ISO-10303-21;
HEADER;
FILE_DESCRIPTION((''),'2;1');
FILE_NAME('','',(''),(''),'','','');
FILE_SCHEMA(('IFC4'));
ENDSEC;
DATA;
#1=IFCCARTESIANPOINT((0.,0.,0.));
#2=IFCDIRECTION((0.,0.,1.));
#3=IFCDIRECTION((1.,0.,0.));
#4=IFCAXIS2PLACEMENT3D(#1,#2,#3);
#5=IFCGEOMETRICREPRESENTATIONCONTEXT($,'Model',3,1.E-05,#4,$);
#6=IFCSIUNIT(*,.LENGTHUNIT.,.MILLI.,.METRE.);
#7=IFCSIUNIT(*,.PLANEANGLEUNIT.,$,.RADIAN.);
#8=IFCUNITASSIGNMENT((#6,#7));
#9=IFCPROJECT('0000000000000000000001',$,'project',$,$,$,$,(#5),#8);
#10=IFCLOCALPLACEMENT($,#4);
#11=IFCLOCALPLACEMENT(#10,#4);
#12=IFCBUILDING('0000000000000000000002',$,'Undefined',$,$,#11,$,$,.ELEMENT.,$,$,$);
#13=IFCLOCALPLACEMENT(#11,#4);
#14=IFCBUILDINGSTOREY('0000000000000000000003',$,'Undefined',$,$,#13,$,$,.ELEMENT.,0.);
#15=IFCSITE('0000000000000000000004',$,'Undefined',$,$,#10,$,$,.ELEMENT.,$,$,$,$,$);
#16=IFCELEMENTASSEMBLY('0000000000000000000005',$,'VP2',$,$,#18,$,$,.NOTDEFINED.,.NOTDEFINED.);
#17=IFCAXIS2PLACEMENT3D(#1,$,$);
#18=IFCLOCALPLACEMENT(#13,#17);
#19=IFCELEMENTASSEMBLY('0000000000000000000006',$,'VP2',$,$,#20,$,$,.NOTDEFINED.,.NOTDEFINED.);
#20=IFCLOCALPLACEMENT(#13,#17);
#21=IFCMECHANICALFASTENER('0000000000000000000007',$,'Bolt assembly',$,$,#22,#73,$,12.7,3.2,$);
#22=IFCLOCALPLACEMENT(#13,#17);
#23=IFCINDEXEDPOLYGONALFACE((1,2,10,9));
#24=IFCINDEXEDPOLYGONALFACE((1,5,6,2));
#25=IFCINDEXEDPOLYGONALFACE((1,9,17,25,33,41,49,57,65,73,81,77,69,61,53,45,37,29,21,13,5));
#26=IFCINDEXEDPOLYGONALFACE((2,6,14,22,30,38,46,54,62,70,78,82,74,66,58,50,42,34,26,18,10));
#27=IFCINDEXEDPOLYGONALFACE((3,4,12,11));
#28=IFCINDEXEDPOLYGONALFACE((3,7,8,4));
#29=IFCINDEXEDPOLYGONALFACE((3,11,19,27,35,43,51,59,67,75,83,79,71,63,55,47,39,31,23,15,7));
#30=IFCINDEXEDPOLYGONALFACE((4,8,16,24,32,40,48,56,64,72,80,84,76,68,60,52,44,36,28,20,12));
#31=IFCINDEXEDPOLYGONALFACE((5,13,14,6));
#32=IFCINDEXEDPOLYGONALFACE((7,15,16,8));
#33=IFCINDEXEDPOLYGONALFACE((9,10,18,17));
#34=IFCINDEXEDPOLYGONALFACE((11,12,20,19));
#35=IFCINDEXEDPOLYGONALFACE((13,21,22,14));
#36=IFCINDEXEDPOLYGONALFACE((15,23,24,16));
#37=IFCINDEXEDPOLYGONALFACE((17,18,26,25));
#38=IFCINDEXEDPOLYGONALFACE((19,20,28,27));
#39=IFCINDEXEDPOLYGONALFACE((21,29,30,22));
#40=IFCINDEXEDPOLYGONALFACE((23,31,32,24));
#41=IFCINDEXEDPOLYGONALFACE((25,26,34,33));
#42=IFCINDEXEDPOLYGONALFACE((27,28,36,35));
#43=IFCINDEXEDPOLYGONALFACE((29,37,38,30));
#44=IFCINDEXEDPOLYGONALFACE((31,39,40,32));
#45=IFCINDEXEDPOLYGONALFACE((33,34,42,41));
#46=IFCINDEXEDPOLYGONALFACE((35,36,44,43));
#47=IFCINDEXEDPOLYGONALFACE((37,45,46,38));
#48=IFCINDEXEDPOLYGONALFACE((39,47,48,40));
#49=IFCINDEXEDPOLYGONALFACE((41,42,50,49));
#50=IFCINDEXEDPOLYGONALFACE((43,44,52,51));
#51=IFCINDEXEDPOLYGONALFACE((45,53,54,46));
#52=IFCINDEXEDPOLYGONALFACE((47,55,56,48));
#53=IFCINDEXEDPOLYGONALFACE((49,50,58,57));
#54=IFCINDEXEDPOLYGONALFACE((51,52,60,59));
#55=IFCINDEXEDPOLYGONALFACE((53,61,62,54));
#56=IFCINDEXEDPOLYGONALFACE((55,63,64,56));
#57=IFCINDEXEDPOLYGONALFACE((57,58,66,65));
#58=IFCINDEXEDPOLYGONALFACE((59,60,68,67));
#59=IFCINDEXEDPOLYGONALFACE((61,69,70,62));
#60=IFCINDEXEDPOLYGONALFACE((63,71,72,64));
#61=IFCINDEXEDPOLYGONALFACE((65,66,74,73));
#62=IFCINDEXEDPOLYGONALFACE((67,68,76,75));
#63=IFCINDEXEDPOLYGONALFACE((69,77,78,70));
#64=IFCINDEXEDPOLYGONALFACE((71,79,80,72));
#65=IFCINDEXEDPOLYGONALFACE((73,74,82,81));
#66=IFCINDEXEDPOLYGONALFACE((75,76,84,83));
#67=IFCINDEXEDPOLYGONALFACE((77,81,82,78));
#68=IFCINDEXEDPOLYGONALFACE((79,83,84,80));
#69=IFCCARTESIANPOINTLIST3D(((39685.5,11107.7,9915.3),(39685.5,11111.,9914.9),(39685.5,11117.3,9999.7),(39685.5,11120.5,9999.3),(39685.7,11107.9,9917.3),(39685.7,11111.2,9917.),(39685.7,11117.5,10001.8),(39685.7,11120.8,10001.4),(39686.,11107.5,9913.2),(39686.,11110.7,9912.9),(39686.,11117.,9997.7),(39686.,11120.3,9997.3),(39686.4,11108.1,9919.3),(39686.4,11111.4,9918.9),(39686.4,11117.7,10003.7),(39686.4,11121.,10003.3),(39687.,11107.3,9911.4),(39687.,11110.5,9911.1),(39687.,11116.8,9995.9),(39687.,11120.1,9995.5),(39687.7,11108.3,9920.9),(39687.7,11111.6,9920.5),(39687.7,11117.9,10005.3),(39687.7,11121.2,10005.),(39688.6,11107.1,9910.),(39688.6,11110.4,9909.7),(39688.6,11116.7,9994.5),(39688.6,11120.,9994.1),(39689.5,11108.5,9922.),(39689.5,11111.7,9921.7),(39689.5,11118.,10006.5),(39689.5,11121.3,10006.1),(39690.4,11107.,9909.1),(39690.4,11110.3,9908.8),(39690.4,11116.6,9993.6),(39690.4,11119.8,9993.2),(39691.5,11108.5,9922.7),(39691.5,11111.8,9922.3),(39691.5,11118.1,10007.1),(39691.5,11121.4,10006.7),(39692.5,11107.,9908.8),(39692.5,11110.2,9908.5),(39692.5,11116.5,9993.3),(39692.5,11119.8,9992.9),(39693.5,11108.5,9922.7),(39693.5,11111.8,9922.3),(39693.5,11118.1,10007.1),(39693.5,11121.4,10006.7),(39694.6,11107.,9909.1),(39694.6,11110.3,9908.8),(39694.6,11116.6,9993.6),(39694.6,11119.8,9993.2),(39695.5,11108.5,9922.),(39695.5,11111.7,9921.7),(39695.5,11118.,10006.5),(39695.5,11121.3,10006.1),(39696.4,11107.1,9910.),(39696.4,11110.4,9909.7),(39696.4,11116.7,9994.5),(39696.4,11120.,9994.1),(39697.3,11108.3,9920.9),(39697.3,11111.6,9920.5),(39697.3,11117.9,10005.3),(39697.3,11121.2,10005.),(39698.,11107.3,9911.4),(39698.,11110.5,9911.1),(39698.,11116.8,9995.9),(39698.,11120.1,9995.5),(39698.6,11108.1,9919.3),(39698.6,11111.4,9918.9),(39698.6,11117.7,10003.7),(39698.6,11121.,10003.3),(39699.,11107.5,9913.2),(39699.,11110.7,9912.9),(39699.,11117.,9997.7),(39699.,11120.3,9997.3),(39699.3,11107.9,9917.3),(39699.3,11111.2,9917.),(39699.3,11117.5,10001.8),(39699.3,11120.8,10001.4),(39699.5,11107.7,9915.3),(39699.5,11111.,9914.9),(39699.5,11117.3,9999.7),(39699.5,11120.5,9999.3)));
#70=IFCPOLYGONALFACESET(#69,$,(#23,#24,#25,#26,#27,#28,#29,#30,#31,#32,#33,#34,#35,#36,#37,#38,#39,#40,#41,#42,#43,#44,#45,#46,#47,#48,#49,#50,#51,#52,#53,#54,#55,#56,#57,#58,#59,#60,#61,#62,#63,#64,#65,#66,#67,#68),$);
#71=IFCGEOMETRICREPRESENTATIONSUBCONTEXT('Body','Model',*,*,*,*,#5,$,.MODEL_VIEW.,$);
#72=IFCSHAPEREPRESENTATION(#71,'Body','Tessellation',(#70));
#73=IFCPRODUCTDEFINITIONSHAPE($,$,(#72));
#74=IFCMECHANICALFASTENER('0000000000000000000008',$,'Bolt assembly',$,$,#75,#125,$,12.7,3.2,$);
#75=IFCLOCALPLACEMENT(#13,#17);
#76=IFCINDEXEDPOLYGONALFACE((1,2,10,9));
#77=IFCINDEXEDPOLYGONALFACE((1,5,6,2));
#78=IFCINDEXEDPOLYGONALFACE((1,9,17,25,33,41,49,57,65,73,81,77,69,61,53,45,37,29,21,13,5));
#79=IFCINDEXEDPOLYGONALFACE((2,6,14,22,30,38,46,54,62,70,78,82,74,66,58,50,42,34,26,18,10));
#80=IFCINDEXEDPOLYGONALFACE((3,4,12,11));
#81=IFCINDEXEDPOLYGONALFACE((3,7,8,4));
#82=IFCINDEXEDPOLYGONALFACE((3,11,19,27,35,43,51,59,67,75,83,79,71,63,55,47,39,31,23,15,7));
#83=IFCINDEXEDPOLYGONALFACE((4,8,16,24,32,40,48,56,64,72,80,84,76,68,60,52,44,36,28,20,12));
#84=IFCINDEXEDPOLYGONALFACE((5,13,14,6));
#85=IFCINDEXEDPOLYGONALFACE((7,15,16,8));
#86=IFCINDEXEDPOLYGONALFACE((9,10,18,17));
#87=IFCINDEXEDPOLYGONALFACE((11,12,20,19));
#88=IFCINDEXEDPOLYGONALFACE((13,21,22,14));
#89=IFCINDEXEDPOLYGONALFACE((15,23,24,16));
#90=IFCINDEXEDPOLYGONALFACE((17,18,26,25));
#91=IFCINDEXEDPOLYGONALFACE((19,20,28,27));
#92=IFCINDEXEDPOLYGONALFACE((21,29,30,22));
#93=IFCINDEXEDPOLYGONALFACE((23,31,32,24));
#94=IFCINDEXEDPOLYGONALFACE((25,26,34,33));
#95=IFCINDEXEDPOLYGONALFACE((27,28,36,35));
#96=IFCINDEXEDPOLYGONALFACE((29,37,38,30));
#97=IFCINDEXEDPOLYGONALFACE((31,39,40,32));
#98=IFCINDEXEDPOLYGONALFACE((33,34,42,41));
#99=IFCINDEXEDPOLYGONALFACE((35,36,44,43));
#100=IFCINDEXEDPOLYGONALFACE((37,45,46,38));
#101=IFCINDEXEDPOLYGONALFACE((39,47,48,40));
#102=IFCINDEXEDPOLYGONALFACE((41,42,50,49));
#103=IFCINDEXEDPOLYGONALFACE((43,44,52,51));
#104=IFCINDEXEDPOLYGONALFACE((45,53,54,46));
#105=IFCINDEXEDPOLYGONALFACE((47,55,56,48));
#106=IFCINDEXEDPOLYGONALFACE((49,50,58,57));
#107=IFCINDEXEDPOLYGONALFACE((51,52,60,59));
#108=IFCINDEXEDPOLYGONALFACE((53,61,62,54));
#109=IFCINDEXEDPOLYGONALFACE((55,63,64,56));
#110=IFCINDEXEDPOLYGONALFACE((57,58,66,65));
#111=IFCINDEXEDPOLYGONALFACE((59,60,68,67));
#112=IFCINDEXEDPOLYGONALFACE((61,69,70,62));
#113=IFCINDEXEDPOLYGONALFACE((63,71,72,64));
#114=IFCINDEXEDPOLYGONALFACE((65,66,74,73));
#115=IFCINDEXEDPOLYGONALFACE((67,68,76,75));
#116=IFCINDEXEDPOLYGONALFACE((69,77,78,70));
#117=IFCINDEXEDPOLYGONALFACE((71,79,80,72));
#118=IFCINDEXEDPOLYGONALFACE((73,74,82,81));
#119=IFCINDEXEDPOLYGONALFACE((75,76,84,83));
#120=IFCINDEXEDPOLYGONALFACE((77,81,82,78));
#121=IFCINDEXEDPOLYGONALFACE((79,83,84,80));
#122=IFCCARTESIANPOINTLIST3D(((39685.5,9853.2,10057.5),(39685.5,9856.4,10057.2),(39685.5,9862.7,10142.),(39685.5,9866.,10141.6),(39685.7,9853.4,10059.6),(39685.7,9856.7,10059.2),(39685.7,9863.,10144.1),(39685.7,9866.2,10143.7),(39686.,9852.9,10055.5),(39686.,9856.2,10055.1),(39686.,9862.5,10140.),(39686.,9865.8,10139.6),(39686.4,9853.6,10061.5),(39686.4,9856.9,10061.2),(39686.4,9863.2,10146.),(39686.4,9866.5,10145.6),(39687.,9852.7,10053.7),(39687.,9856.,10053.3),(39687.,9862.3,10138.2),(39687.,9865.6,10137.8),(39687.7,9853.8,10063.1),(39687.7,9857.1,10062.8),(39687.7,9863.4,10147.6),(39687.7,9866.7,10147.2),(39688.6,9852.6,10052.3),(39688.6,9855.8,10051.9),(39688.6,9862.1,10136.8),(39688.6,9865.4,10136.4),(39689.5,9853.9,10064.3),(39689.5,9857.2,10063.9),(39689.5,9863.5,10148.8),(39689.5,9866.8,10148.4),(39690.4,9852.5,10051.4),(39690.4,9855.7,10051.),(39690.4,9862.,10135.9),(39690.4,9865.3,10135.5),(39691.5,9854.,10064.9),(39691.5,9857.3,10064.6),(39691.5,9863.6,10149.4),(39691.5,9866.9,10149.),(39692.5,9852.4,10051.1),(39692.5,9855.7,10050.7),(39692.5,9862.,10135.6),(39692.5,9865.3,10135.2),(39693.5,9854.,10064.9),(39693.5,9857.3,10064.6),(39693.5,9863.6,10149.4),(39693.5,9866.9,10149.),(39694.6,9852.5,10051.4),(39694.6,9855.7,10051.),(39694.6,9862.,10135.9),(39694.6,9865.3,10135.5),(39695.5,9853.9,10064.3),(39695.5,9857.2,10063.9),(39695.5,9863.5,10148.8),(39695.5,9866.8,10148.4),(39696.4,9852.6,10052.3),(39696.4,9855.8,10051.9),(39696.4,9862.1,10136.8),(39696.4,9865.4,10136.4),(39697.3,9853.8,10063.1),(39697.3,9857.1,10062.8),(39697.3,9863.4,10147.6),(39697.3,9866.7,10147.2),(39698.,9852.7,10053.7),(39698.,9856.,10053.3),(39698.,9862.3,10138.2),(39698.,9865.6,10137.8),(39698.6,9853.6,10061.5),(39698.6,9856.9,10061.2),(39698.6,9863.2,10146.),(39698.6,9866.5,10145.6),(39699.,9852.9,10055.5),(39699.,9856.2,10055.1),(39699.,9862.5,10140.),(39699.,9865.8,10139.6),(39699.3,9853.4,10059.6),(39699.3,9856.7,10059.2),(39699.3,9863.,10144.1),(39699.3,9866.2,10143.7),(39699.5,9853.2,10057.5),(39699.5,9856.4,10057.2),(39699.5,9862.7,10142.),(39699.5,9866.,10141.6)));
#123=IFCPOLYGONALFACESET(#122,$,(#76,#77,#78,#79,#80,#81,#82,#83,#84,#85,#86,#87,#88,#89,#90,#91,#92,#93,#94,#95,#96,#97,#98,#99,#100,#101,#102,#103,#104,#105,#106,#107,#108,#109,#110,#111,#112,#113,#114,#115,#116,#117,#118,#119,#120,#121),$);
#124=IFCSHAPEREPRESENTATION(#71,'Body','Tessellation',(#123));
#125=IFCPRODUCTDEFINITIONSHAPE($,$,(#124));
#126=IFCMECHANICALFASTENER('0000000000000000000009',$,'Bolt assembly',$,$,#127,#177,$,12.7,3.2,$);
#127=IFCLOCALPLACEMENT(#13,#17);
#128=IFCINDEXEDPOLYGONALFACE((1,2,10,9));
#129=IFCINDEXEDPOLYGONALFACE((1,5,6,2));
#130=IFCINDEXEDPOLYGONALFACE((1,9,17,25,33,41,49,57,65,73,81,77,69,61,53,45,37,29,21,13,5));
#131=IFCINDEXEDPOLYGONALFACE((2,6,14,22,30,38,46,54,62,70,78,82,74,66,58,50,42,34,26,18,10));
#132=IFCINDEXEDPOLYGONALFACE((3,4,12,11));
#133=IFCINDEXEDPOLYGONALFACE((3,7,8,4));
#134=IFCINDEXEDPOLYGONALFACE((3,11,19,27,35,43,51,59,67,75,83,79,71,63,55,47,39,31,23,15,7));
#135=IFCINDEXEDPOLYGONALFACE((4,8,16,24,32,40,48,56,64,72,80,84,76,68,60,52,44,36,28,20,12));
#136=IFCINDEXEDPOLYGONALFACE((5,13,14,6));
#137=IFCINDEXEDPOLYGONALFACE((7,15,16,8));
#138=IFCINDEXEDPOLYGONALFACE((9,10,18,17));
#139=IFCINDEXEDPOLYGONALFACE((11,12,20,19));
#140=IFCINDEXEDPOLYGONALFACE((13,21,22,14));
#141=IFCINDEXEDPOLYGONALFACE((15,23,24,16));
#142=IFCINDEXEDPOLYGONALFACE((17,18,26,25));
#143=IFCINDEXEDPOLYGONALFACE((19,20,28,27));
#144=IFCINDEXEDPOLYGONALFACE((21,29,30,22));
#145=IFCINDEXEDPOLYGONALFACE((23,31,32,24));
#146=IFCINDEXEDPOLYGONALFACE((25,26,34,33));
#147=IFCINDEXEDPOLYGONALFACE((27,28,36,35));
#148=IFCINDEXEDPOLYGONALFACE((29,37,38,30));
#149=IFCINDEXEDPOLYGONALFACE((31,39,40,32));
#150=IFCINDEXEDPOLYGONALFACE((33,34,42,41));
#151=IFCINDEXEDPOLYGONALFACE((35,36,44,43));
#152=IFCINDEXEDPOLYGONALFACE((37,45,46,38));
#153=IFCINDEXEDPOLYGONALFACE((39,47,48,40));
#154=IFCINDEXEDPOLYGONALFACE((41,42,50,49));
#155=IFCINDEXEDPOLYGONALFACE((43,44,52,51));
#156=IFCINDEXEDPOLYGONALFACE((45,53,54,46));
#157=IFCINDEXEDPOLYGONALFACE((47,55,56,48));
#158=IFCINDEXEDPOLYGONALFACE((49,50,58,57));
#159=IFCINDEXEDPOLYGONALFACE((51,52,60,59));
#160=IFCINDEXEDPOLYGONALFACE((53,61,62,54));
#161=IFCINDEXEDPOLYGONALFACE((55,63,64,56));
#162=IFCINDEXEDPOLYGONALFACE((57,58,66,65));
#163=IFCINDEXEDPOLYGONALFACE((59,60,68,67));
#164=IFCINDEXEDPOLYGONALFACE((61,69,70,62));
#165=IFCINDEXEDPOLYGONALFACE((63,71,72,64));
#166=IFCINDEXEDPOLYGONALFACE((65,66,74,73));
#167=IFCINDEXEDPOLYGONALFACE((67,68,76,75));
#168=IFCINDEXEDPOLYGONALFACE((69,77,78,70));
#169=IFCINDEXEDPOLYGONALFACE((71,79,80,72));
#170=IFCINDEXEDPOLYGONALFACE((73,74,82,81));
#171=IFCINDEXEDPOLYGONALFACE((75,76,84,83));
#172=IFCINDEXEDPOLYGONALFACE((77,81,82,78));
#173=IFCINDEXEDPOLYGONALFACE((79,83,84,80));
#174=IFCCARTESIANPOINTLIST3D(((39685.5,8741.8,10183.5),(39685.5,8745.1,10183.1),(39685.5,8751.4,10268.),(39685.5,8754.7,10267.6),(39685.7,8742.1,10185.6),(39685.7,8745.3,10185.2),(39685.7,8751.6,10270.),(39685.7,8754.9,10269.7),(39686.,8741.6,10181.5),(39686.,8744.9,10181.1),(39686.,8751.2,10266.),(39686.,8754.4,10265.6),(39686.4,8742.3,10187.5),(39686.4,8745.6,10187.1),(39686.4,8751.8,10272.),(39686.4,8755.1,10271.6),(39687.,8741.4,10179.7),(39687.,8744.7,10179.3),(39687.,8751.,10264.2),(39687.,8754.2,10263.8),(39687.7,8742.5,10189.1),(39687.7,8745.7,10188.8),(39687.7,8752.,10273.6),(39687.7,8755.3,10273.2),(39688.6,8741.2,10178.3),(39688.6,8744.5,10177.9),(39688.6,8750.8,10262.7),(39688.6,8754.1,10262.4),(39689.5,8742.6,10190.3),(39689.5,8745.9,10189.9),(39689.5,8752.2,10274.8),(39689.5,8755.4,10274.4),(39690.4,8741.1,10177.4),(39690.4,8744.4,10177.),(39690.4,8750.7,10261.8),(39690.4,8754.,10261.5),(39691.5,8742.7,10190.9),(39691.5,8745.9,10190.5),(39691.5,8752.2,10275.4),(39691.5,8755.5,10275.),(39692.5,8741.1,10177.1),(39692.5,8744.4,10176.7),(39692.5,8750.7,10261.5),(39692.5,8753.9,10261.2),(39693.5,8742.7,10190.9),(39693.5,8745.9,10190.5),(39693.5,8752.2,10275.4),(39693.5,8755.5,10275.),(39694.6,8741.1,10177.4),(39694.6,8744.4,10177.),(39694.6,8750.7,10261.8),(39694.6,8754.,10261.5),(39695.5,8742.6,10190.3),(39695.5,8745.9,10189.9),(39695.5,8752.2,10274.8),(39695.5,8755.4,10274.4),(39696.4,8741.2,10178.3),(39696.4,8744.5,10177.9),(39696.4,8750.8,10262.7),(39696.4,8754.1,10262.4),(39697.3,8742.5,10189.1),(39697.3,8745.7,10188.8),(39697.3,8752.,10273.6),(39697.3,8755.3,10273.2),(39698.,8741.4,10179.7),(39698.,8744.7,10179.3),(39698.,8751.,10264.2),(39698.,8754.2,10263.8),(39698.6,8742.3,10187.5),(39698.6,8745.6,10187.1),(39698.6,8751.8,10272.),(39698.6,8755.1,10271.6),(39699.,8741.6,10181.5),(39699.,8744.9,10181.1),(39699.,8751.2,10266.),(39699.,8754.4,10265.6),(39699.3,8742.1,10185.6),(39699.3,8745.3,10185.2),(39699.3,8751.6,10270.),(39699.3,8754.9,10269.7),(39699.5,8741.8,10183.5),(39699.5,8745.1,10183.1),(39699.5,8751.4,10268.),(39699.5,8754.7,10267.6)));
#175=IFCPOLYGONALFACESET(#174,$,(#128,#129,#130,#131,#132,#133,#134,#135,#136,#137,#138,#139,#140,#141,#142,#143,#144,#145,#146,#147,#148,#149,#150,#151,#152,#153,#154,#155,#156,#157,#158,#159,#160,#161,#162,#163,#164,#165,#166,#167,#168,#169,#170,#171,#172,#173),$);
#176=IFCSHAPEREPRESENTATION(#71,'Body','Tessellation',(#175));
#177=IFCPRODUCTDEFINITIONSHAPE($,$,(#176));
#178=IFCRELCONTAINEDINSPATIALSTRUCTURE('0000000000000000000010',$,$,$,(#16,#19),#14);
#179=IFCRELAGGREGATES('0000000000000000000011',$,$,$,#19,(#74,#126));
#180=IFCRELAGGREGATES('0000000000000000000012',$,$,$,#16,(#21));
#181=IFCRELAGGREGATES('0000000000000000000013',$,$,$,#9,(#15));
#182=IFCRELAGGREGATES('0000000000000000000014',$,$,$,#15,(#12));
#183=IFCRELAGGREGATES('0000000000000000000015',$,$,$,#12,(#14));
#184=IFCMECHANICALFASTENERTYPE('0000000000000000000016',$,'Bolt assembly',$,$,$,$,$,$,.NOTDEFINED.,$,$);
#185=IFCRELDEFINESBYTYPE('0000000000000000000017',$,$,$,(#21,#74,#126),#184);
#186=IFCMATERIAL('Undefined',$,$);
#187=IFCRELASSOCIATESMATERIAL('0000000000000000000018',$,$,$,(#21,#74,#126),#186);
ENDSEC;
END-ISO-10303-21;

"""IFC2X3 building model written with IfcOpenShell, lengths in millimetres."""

from ifc_helpers import new_model, si_unit, frame, origin_with_axes, origin_2d_with_axis, place, context, subcontext, project, spatial, circle, extrude, source, transform, mapped, material, type_object, element, aggregate, save


model = new_model("IFC2X3")

# Units and contexts
model_context = context("Model", 3, precision=1e-05, world=origin_with_axes())
body_context = subcontext(model_context, "Body", "Model", "MODEL_VIEW")
ifc_project = project(units=[si_unit("LENGTHUNIT", "METRE", prefix="MILLI"), si_unit("PLANEANGLEUNIT", "RADIAN")], contexts=[model_context])

# Site, building, storey
site_placement = place(None, origin_with_axes())
site = spatial("IfcSite", under=ifc_project, at=site_placement, Name="Undefined", CompositionType="ELEMENT")
building_placement = place(site_placement, origin_with_axes())
building = spatial("IfcBuilding", under=site, at=building_placement, Name="Undefined", CompositionType="ELEMENT")
storey_placement = place(building_placement, origin_with_axes())
storey = spatial("IfcBuildingStorey", under=building, at=storey_placement, Name="Undefined", CompositionType="ELEMENT", Elevation=0.0)

# Element assembly
assembly_1_placement = place(storey_placement, origin_with_axes())
assembly_1 = element("IfcElementAssembly", 1, at=assembly_1_placement, inside=storey, Name="VP2", AssemblyPlace="NOTDEFINED", PredefinedType="NOTDEFINED")

# Element assembly
assembly_2_placement = place(storey_placement, origin_with_axes())
assembly_2 = element("IfcElementAssembly", 2, at=assembly_2_placement, inside=storey, Name="VP2", AssemblyPlace="NOTDEFINED", PredefinedType="NOTDEFINED")

# Mechanical fastener
ifc_material_1 = material(Name="Undefined")
mechanical_fastener_type = type_object("IfcMechanicalFastenerType", Name="Bolt assembly")
shared_shape_1 = source(origin_with_axes(), body_context, "Body", "SweptSolid", [
    extrude(circle(Radius=7.0, at=origin_2d_with_axis()), frame((0.0, -3.2, 0.0), z_axis=(0.0, 1.0, 0.0), x_axis=(1.0, 0.0, 0.0)), (0.0, 0.0, 1.0), 3.3),
])
mechanical_fastener_1_placement = place(assembly_1_placement, frame((39692.5, 11117.4, 10000.2), z_axis=(-1.0, 0.0, 0.0), x_axis=(0.0, -0.112644, -0.993635)))
mechanical_fastener_1 = element("IfcMechanicalFastener", 3, at=mechanical_fastener_1_placement, type_object=mechanical_fastener_type, material=ifc_material_1, Name="Bolt assembly", NominalDiameter=12.7, NominalLength=3.2, context=body_context, shape_type="MappedRepresentation", body=[
    mapped(shared_shape_1, transform((0.0, 0.0, 0.0))),
    mapped(shared_shape_1, transform((85.0, 0.0, 0.0))),
])

# Mechanical fasteners
shared_shape_2 = source(origin_with_axes(), body_context, "Body", "SweptSolid", [
    extrude(circle(Radius=7.0, at=origin_2d_with_axis()), frame((0.0, -3.2, 0.0), z_axis=(0.0, 1.0, 0.0), x_axis=(1.0, 0.0, 0.0)), (0.0, 0.0, 1.0), 3.3),
])
mechanical_fastener_2_placement = place(assembly_2_placement, frame((39692.5, 9866.0, 10142.1), z_axis=(1.0, 0.0, 0.0), x_axis=(0.0, -0.112644, -0.993635)))
mechanical_fastener_2 = element("IfcMechanicalFastener", 4, at=mechanical_fastener_2_placement, type_object=mechanical_fastener_type, material=ifc_material_1, Name="Bolt assembly", NominalDiameter=12.7, NominalLength=3.2, context=body_context, shape_type="MappedRepresentation", body=[
    mapped(shared_shape_2, transform((0.0, 0.0, 0.0))),
    mapped(shared_shape_2, transform((85.0, 0.0, 0.0))),
])
mechanical_fastener_3_placement = place(assembly_2_placement, frame((39692.5, 8754.6, 10268.1), z_axis=(1.0, 0.0, 0.0), x_axis=(0.0, -0.112644, -0.993635)))
mechanical_fastener_3 = element("IfcMechanicalFastener", 5, at=mechanical_fastener_3_placement, type_object=mechanical_fastener_type, material=ifc_material_1, Name="Bolt assembly", NominalDiameter=12.7, NominalLength=3.2, context=body_context, shape_type="MappedRepresentation", body=[
    mapped(shared_shape_2, transform((0.0, 0.0, 0.0))),
    mapped(shared_shape_2, transform((85.0, 0.0, 0.0))),
])
aggregate(assembly_2, [mechanical_fastener_2, mechanical_fastener_3])
aggregate(assembly_1, [mechanical_fastener_1])

save(model, "model.ifc")
